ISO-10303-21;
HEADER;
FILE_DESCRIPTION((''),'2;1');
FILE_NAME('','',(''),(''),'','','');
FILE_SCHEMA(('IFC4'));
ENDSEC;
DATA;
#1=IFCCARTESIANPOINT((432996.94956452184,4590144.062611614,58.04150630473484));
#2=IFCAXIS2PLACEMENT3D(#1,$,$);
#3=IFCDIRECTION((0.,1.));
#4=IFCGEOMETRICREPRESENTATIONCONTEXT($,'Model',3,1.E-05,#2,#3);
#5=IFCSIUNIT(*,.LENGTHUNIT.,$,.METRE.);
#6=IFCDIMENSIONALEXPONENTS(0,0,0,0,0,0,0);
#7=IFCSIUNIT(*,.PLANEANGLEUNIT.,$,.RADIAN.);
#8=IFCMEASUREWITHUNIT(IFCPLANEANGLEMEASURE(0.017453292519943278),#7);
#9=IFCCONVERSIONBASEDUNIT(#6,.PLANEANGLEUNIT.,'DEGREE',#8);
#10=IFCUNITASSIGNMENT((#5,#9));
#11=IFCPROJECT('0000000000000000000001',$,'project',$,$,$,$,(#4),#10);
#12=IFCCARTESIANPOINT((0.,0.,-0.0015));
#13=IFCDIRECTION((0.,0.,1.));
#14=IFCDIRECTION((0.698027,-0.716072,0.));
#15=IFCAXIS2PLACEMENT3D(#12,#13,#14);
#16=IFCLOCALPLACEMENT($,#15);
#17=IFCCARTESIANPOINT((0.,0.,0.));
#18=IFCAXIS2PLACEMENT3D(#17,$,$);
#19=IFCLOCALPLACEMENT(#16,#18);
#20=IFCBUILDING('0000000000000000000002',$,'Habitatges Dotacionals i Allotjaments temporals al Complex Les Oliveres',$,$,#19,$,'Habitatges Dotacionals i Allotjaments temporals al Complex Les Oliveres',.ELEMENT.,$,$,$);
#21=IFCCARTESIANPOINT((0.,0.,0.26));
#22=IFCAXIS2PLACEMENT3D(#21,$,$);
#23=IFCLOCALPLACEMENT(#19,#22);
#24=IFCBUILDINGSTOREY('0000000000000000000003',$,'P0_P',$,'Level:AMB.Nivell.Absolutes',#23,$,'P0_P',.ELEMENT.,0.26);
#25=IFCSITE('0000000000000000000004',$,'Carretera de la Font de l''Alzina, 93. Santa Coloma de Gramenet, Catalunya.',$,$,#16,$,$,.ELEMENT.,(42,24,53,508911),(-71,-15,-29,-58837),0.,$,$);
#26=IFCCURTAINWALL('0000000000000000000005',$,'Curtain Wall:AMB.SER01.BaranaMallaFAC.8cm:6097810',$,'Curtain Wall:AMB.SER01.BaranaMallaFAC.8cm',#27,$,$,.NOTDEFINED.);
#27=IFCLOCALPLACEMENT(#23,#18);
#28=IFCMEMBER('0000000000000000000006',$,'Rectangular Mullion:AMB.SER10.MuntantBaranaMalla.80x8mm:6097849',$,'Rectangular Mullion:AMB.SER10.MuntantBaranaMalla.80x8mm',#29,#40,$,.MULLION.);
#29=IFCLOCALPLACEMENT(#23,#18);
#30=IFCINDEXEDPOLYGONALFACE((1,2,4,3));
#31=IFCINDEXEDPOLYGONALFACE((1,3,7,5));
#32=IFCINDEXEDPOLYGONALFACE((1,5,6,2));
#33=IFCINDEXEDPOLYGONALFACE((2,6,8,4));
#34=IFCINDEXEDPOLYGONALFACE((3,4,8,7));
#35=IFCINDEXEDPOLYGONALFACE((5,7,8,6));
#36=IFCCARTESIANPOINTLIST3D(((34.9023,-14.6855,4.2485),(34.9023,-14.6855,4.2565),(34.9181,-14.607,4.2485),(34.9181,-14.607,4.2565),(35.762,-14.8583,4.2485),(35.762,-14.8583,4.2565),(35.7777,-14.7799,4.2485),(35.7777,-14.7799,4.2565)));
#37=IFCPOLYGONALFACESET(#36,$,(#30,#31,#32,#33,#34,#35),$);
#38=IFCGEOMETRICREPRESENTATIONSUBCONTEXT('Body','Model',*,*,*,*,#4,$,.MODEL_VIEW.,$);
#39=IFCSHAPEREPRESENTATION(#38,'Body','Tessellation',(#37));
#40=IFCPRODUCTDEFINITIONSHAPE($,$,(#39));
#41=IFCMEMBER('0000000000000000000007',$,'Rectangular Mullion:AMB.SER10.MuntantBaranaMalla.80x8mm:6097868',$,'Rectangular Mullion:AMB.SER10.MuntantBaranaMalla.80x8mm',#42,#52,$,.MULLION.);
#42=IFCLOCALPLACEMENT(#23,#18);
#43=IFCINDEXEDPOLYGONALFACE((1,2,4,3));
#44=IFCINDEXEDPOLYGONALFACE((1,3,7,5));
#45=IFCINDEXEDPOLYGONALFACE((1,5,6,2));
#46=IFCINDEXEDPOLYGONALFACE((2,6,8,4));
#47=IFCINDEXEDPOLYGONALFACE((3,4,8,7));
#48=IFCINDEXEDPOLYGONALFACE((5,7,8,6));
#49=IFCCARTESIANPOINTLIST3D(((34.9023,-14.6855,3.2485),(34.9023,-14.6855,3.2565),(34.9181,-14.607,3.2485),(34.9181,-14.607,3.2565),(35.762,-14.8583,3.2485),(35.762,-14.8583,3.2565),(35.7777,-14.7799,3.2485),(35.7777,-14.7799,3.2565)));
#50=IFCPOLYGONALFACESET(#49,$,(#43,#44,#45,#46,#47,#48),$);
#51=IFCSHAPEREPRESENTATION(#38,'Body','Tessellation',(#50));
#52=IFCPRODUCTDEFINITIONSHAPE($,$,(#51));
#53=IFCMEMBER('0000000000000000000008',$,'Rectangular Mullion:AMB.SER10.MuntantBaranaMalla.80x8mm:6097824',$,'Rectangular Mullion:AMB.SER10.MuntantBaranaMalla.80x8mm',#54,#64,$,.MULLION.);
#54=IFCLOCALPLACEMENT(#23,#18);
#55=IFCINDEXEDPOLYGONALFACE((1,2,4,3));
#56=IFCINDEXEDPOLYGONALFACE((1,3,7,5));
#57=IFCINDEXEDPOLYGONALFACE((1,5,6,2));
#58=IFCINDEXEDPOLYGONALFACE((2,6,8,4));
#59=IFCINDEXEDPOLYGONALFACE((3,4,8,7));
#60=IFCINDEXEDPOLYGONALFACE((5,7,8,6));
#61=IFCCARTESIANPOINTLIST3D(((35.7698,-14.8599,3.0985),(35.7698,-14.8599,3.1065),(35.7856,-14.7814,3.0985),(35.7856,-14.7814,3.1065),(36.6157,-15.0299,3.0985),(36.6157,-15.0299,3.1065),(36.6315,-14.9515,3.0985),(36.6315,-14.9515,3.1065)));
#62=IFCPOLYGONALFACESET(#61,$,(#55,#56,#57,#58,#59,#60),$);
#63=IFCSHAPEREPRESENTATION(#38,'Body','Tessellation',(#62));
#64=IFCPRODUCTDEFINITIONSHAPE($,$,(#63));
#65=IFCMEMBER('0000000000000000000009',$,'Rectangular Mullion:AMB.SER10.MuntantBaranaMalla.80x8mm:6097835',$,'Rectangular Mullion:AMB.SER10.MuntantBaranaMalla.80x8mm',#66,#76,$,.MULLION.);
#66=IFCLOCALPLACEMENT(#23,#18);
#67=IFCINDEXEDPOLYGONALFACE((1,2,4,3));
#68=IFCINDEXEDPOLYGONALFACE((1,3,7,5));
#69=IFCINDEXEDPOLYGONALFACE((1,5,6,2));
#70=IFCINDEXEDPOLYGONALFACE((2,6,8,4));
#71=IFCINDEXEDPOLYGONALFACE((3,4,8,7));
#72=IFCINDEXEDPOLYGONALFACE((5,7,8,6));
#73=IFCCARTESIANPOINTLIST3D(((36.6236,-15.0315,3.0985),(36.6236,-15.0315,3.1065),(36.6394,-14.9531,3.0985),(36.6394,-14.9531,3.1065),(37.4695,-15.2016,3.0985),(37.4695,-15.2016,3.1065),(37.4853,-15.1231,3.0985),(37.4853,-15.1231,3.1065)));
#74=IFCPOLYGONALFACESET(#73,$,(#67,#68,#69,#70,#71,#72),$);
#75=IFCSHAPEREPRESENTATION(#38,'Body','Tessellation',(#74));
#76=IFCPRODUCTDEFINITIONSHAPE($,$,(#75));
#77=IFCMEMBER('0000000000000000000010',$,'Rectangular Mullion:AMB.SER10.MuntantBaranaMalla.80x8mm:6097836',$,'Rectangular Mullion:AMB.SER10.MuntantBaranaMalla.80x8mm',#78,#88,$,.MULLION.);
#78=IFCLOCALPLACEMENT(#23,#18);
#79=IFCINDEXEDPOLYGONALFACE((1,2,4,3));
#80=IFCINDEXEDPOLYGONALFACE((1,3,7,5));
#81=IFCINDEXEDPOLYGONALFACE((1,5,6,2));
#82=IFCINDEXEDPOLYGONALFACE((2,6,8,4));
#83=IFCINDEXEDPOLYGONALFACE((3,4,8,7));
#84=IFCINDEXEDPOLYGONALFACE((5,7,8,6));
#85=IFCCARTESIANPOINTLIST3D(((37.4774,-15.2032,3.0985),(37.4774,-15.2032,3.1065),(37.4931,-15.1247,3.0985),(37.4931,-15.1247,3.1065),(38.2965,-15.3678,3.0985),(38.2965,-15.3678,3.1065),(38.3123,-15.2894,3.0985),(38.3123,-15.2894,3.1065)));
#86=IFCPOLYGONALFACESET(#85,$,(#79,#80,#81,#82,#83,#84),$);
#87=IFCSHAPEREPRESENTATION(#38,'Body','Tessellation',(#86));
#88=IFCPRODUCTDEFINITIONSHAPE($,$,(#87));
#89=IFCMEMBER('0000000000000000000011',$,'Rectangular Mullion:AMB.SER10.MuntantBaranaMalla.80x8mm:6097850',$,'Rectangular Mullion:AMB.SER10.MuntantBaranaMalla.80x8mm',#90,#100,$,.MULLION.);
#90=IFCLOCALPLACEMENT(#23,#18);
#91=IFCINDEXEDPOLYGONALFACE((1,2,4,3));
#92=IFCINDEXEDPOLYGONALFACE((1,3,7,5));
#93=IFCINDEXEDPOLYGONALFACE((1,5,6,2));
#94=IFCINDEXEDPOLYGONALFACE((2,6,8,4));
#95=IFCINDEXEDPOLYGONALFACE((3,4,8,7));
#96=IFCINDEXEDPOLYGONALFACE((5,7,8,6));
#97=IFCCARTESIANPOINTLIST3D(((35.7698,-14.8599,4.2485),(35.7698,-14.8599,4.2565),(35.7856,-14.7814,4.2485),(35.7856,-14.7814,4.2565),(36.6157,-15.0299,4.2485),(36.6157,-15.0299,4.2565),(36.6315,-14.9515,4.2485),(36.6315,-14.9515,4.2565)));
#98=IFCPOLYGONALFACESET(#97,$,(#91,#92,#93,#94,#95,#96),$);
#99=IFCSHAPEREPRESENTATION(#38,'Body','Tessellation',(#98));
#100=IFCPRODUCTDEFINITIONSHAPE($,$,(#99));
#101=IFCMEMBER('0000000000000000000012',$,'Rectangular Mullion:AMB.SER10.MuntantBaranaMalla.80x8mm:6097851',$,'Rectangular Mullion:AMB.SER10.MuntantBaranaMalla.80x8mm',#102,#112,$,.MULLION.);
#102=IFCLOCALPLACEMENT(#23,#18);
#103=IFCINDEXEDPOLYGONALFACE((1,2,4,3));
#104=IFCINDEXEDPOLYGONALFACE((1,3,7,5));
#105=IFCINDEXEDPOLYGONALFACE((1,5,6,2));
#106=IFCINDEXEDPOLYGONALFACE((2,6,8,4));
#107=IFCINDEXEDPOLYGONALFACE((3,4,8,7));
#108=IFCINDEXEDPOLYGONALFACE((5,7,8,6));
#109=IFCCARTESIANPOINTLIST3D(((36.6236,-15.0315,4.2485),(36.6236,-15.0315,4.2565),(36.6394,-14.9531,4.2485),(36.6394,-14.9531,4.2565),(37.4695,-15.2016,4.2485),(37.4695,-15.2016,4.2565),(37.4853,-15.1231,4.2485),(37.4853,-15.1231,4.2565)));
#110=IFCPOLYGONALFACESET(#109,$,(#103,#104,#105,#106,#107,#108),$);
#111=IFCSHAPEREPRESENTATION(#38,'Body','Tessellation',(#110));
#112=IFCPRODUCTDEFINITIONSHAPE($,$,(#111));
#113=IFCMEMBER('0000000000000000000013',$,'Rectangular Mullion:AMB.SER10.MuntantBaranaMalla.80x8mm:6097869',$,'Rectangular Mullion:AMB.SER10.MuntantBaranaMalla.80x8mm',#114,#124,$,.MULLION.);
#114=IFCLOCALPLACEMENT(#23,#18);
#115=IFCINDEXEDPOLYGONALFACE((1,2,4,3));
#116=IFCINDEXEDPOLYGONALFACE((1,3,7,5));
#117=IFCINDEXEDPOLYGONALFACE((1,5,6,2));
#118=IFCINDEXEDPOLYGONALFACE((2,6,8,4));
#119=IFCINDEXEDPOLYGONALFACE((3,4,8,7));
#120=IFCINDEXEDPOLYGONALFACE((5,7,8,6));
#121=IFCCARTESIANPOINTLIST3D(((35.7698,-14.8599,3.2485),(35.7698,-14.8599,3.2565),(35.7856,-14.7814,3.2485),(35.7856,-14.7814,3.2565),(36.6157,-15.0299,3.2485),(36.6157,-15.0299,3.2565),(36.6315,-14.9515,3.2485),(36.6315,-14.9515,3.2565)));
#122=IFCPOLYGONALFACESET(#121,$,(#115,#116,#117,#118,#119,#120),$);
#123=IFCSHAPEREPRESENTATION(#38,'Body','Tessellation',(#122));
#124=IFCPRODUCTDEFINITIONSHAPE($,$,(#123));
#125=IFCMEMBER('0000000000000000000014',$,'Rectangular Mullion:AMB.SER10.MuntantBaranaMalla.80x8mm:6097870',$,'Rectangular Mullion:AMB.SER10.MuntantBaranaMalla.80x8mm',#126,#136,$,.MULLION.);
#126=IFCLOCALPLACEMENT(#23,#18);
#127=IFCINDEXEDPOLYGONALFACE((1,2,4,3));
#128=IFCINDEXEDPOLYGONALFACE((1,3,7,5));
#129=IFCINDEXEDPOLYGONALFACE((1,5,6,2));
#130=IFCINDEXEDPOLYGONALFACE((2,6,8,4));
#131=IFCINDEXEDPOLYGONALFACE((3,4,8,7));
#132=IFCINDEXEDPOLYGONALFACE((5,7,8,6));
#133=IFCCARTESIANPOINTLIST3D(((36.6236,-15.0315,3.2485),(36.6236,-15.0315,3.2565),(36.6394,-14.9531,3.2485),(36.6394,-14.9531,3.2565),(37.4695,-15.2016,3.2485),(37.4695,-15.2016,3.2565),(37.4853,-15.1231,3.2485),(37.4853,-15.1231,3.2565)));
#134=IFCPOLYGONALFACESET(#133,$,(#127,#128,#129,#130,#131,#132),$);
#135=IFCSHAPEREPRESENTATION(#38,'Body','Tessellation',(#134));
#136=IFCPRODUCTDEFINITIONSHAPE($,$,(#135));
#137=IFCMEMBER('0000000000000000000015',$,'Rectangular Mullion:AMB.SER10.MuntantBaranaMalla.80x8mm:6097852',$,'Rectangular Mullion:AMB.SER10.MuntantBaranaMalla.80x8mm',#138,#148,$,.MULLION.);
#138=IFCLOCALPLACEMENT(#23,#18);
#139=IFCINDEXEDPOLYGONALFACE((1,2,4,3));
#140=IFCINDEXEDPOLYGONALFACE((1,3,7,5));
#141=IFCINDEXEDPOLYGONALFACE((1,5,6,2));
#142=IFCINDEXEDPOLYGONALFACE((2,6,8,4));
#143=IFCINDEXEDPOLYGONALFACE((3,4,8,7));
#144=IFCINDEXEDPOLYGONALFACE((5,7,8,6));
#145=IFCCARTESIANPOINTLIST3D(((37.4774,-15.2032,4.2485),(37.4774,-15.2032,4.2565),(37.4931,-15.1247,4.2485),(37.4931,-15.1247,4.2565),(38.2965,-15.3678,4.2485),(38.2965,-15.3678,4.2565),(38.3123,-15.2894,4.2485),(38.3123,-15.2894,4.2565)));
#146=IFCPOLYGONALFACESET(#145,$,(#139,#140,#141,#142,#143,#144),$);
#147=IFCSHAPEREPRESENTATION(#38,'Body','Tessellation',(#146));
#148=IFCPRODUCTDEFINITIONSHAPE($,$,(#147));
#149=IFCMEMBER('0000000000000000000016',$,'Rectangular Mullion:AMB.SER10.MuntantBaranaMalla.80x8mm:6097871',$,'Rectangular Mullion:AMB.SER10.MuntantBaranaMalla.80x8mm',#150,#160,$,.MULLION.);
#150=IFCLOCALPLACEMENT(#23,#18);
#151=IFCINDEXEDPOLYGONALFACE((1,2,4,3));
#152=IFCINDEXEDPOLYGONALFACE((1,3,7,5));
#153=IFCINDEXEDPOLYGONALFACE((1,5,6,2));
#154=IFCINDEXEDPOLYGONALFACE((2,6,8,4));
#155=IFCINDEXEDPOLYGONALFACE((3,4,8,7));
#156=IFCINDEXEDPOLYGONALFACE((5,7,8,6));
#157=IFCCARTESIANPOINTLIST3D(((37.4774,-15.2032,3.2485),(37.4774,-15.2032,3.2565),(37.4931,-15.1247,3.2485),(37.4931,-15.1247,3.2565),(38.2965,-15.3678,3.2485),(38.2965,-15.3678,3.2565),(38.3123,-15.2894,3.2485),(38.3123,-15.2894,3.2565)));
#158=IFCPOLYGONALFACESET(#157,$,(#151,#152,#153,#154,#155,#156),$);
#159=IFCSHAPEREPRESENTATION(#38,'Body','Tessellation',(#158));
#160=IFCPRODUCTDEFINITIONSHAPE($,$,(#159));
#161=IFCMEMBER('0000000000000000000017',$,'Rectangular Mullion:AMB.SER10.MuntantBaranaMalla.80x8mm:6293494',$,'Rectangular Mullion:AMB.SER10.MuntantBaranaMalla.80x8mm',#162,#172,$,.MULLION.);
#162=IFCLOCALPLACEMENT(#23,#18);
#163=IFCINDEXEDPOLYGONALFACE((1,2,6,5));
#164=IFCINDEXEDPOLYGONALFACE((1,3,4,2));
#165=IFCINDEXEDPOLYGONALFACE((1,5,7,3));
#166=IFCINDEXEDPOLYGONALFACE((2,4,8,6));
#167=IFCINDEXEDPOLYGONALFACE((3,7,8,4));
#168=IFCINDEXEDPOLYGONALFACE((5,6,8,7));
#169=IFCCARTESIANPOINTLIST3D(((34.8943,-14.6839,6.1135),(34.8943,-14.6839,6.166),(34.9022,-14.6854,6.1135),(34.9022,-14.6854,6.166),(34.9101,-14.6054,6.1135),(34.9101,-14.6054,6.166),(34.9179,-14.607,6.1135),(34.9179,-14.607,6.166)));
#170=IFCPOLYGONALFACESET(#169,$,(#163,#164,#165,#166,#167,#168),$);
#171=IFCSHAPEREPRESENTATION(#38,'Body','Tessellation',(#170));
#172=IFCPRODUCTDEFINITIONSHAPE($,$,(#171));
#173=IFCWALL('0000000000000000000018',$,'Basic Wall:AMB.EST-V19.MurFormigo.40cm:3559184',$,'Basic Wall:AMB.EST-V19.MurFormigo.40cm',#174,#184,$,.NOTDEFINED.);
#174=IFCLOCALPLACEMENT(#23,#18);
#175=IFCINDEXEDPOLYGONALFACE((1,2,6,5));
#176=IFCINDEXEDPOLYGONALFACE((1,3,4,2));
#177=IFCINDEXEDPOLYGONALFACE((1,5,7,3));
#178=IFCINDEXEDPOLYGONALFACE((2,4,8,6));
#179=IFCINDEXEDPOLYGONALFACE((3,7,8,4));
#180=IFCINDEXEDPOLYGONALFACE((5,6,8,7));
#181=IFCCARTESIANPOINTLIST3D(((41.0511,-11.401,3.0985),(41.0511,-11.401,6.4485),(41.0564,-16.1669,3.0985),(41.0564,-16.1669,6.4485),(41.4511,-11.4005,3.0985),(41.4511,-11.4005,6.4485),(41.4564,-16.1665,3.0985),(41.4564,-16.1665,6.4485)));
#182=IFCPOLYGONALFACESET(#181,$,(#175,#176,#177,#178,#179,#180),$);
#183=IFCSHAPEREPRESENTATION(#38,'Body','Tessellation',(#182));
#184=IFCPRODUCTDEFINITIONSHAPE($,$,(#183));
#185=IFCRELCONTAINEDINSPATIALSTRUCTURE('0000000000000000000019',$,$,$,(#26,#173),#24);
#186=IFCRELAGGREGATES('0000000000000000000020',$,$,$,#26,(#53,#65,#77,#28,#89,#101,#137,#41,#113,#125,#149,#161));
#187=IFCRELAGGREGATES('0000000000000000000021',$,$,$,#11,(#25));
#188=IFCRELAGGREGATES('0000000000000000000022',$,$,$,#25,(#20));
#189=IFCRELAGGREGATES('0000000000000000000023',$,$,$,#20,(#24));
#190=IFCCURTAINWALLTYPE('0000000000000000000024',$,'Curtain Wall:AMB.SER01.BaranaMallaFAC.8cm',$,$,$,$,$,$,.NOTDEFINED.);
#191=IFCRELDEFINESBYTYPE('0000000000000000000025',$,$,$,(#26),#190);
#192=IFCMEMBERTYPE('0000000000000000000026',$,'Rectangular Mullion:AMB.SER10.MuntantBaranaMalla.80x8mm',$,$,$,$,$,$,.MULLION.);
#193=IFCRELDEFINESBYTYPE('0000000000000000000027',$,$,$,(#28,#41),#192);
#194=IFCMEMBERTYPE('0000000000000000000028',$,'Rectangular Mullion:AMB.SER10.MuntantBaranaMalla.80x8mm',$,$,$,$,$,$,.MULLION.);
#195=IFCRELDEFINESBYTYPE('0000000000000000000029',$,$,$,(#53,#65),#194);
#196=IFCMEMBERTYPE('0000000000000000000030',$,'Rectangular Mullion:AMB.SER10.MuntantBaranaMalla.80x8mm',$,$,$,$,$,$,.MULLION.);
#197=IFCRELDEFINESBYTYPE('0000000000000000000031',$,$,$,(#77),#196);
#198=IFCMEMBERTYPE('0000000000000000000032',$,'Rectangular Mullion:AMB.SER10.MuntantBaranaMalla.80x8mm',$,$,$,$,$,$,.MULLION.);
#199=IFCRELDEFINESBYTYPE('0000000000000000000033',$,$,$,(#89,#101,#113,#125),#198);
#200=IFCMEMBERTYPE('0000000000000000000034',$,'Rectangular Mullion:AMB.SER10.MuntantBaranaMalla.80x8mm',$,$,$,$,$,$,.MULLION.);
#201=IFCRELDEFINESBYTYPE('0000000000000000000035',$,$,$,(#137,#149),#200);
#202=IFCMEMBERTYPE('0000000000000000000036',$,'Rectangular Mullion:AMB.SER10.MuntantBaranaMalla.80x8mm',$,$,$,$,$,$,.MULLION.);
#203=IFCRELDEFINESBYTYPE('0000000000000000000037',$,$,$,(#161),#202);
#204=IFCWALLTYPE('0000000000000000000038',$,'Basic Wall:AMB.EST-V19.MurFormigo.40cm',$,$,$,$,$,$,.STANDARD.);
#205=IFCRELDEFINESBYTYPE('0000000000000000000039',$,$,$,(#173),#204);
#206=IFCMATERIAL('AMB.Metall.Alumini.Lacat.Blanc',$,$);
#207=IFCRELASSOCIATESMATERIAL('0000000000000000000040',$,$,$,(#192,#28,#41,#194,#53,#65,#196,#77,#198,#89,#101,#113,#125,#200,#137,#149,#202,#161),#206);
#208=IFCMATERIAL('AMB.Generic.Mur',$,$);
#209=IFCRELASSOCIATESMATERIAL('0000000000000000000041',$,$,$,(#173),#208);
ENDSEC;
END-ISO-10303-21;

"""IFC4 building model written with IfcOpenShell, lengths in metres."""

from ifc_helpers import new_model, entity, si_unit, converted_unit, direction, frame, origin, place, context, subcontext, project, spatial, indexed_curve, outline, extrude, source, transform, mapped, material, type_object, type_shapes, element, aggregate, save


model = new_model("IFC4")

# Units and contexts
model_context = context("Model", 3, precision=1e-05, world=frame((432996.94956452184, 4590144.062611614, 58.04150630473484)), true_north=direction((0.0, 1.0)))
body_context = subcontext(model_context, "Body", "Model", "MODEL_VIEW")
ifc_project = project(units=[si_unit("LENGTHUNIT", "METRE"), converted_unit("PLANEANGLEUNIT", "DEGREE", entity("IfcPlaneAngleMeasure", 0.017453292519943278), si_unit("PLANEANGLEUNIT", "RADIAN"), dimensions=[0, 0, 0, 0, 0, 0, 0])], contexts=[model_context])

# Site, building, storey
site_placement = place(None, frame((0.0, 0.0, -0.0015), z_axis=(0.0, 0.0, 1.0), x_axis=(0.698027, -0.716072, 0.0)))
site = spatial("IfcSite", under=ifc_project, at=site_placement, Name="Carretera de la Font de l'Alzina, 93. Santa Coloma de Gramenet, Catalunya.", CompositionType="ELEMENT", RefLatitude=(42, 24, 53, 508911), RefLongitude=(-71, -15, -29, -58837), RefElevation=0.0)
building_placement = place(site_placement, origin())
building = spatial("IfcBuilding", under=site, at=building_placement, Name="Habitatges Dotacionals i Allotjaments temporals al Complex Les Oliveres", LongName="Habitatges Dotacionals i Allotjaments temporals al Complex Les Oliveres", CompositionType="ELEMENT")
storey_placement = place(building_placement, frame((0.0, 0.0, 0.26)))
storey = spatial("IfcBuildingStorey", under=building, at=storey_placement, Name="P0_P", ObjectType="Level:AMB.Nivell.Absolutes", LongName="P0_P", CompositionType="ELEMENT", Elevation=0.26)

# Curtain wall, members
curtain_wall_type = type_object("IfcCurtainWallType", Name="Curtain Wall:AMB.SER01.BaranaMallaFAC.8cm", PredefinedType="NOTDEFINED")
curtain_wall_placement = place(storey_placement, frame((0.0, 0.0, -0.26)))
curtain_wall = element("IfcCurtainWall", 1, at=curtain_wall_placement, inside=storey, type_object=curtain_wall_type, Name="Curtain Wall:AMB.SER01.BaranaMallaFAC.8cm:6097810", ObjectType="Curtain Wall:AMB.SER01.BaranaMallaFAC.8cm", PredefinedType="NOTDEFINED")
ifc_material_1 = material(Name="AMB.Metall.Alumini.Lacat.Blanc")
member_type_1 = type_object("IfcMemberType", Name="Rectangular Mullion:AMB.SER10.MuntantBaranaMalla.80x8mm", PredefinedType="MULLION", material=ifc_material_1)
shared_shape_1 = source(origin(), body_context, "Body", "SweptSolid", [
    extrude(outline(indexed_curve([(-0.004, -0.04), (0.004, -0.04), (0.004, 0.04), (-0.004, 0.04), (-0.004, -0.04)], self_intersect=False)), frame((0.0, -0.04, -0.8769), z_axis=(0.0, 0.0, 1.0), x_axis=(-1.0, 0.0, 0.0)), (0.0, 0.0, 1.0), 0.8769),
])
type_shapes(member_type_1, [shared_shape_1])
member_1_placement = place(curtain_wall_placement, frame((35.762, -14.8583, 4.5125), z_axis=(0.980384, -0.197097, 0.0), x_axis=(0.0, 0.0, 1.0)))
member_1 = element("IfcMember", 2, at=member_1_placement, type_object=member_type_1, material=ifc_material_1, Name="Rectangular Mullion:AMB.SER10.MuntantBaranaMalla.80x8mm:6097849", ObjectType="Rectangular Mullion:AMB.SER10.MuntantBaranaMalla.80x8mm", PredefinedType="MULLION", context=body_context, shape_type="MappedRepresentation", body=[
    mapped(shared_shape_1, transform((0.0, 0.0, 0.0), scale=1.0)),
])
member_2_placement = place(curtain_wall_placement, frame((35.762, -14.8583, 3.5125), z_axis=(0.980384, -0.197097, 0.0), x_axis=(0.0, 0.0, 1.0)))
member_2 = element("IfcMember", 3, at=member_2_placement, type_object=member_type_1, material=ifc_material_1, Name="Rectangular Mullion:AMB.SER10.MuntantBaranaMalla.80x8mm:6097868", ObjectType="Rectangular Mullion:AMB.SER10.MuntantBaranaMalla.80x8mm", PredefinedType="MULLION", context=body_context, shape_type="MappedRepresentation", body=[
    mapped(shared_shape_1, transform((0.0, 0.0, 0.0), scale=1.0)),
])
member_type_2 = type_object("IfcMemberType", Name="Rectangular Mullion:AMB.SER10.MuntantBaranaMalla.80x8mm", PredefinedType="MULLION", material=ifc_material_1)
shared_shape_2 = source(origin(), body_context, "Body", "SweptSolid", [
    extrude(outline(indexed_curve([(-0.004, -0.04), (0.004, -0.04), (0.004, 0.04), (-0.004, 0.04), (-0.004, -0.04)], self_intersect=False)), frame((-0.004, -0.04, -0.8629), z_axis=(0.0, 0.0, 1.0), x_axis=(-1.0, 0.0, 0.0)), (0.0, 0.0, 1.0), 0.8629),
])
type_shapes(member_type_2, [shared_shape_2])
member_3_placement = place(curtain_wall_placement, frame((35.7698, -14.8599, 3.3585), z_axis=(-0.980384, 0.197097, 0.0), x_axis=(0.0, 0.0, -1.0)))
member_3 = element("IfcMember", 4, at=member_3_placement, type_object=member_type_2, material=ifc_material_1, Name="Rectangular Mullion:AMB.SER10.MuntantBaranaMalla.80x8mm:6097824", ObjectType="Rectangular Mullion:AMB.SER10.MuntantBaranaMalla.80x8mm", PredefinedType="MULLION", context=body_context, shape_type="MappedRepresentation", body=[
    mapped(shared_shape_2, transform((0.0, 0.0, 0.0), scale=1.0)),
])
member_4_placement = place(curtain_wall_placement, frame((36.6236, -15.0315, 3.3585), z_axis=(-0.980384, 0.197097, 0.0), x_axis=(0.0, 0.0, -1.0)))
member_4 = element("IfcMember", 5, at=member_4_placement, type_object=member_type_2, material=ifc_material_1, Name="Rectangular Mullion:AMB.SER10.MuntantBaranaMalla.80x8mm:6097835", ObjectType="Rectangular Mullion:AMB.SER10.MuntantBaranaMalla.80x8mm", PredefinedType="MULLION", context=body_context, shape_type="MappedRepresentation", body=[
    mapped(shared_shape_2, transform((0.0, 0.0, 0.0), scale=1.0)),
])
member_type_3 = type_object("IfcMemberType", Name="Rectangular Mullion:AMB.SER10.MuntantBaranaMalla.80x8mm", PredefinedType="MULLION", material=ifc_material_1)
shared_shape_3 = source(origin(), body_context, "Body", "SweptSolid", [
    extrude(outline(indexed_curve([(-0.004, -0.04), (0.004, -0.04), (0.004, 0.04), (-0.004, 0.04), (-0.004, -0.04)], self_intersect=False)), frame((-0.004, -0.04, -0.8356), z_axis=(0.0, 0.0, 1.0), x_axis=(-1.0, 0.0, 0.0)), (0.0, 0.0, 1.0), 0.8356),
])
type_shapes(member_type_3, [shared_shape_3])
member_5_placement = place(curtain_wall_placement, frame((37.4774, -15.2032, 3.3585), z_axis=(-0.980384, 0.197097, 0.0), x_axis=(0.0, 0.0, -1.0)))
member_5 = element("IfcMember", 6, at=member_5_placement, type_object=member_type_3, material=ifc_material_1, Name="Rectangular Mullion:AMB.SER10.MuntantBaranaMalla.80x8mm:6097836", ObjectType="Rectangular Mullion:AMB.SER10.MuntantBaranaMalla.80x8mm", PredefinedType="MULLION", context=body_context, shape_type="MappedRepresentation", body=[
    mapped(shared_shape_3, transform((0.0, 0.0, 0.0), scale=1.0)),
])
member_type_4 = type_object("IfcMemberType", Name="Rectangular Mullion:AMB.SER10.MuntantBaranaMalla.80x8mm", PredefinedType="MULLION", material=ifc_material_1)
shared_shape_4 = source(origin(), body_context, "Body", "SweptSolid", [
    extrude(outline(indexed_curve([(-0.004, -0.04), (0.004, -0.04), (0.004, 0.04), (-0.004, 0.04), (-0.004, -0.04)], self_intersect=False)), frame((0.0, -0.04, -0.8629), z_axis=(0.0, 0.0, 1.0), x_axis=(-1.0, 0.0, 0.0)), (0.0, 0.0, 1.0), 0.8629),
])
type_shapes(member_type_4, [shared_shape_4])
member_6_placement = place(curtain_wall_placement, frame((36.6157, -15.0299, 4.5125), z_axis=(0.980384, -0.197097, 0.0), x_axis=(0.0, 0.0, 1.0)))
member_6 = element("IfcMember", 7, at=member_6_placement, type_object=member_type_4, material=ifc_material_1, Name="Rectangular Mullion:AMB.SER10.MuntantBaranaMalla.80x8mm:6097850", ObjectType="Rectangular Mullion:AMB.SER10.MuntantBaranaMalla.80x8mm", PredefinedType="MULLION", context=body_context, shape_type="MappedRepresentation", body=[
    mapped(shared_shape_4, transform((0.0, 0.0, 0.0), scale=1.0)),
])
member_7_placement = place(curtain_wall_placement, frame((37.4695, -15.2016, 4.5125), z_axis=(0.980384, -0.197097, 0.0), x_axis=(0.0, 0.0, 1.0)))
member_7 = element("IfcMember", 8, at=member_7_placement, type_object=member_type_4, material=ifc_material_1, Name="Rectangular Mullion:AMB.SER10.MuntantBaranaMalla.80x8mm:6097851", ObjectType="Rectangular Mullion:AMB.SER10.MuntantBaranaMalla.80x8mm", PredefinedType="MULLION", context=body_context, shape_type="MappedRepresentation", body=[
    mapped(shared_shape_4, transform((0.0, 0.0, 0.0), scale=1.0)),
])
member_8_placement = place(curtain_wall_placement, frame((36.6157, -15.0299, 3.5125), z_axis=(0.980384, -0.197097, 0.0), x_axis=(0.0, 0.0, 1.0)))
member_8 = element("IfcMember", 9, at=member_8_placement, type_object=member_type_4, material=ifc_material_1, Name="Rectangular Mullion:AMB.SER10.MuntantBaranaMalla.80x8mm:6097869", ObjectType="Rectangular Mullion:AMB.SER10.MuntantBaranaMalla.80x8mm", PredefinedType="MULLION", context=body_context, shape_type="MappedRepresentation", body=[
    mapped(shared_shape_4, transform((0.0, 0.0, 0.0), scale=1.0)),
])
member_9_placement = place(curtain_wall_placement, frame((37.4695, -15.2016, 3.5125), z_axis=(0.980384, -0.197097, 0.0), x_axis=(0.0, 0.0, 1.0)))
member_9 = element("IfcMember", 10, at=member_9_placement, type_object=member_type_4, material=ifc_material_1, Name="Rectangular Mullion:AMB.SER10.MuntantBaranaMalla.80x8mm:6097870", ObjectType="Rectangular Mullion:AMB.SER10.MuntantBaranaMalla.80x8mm", PredefinedType="MULLION", context=body_context, shape_type="MappedRepresentation", body=[
    mapped(shared_shape_4, transform((0.0, 0.0, 0.0), scale=1.0)),
])
member_type_5 = type_object("IfcMemberType", Name="Rectangular Mullion:AMB.SER10.MuntantBaranaMalla.80x8mm", PredefinedType="MULLION", material=ifc_material_1)
shared_shape_5 = source(origin(), body_context, "Body", "SweptSolid", [
    extrude(outline(indexed_curve([(-0.004, -0.04), (0.004, -0.04), (0.004, 0.04), (-0.004, 0.04), (-0.004, -0.04)], self_intersect=False)), frame((0.0, -0.04, -0.8356), z_axis=(0.0, 0.0, 1.0), x_axis=(-1.0, 0.0, 0.0)), (0.0, 0.0, 1.0), 0.8356),
])
type_shapes(member_type_5, [shared_shape_5])
member_10_placement = place(curtain_wall_placement, frame((38.2965, -15.3678, 4.5125), z_axis=(0.980384, -0.197097, 0.0), x_axis=(0.0, 0.0, 1.0)))
member_10 = element("IfcMember", 11, at=member_10_placement, type_object=member_type_5, material=ifc_material_1, Name="Rectangular Mullion:AMB.SER10.MuntantBaranaMalla.80x8mm:6097852", ObjectType="Rectangular Mullion:AMB.SER10.MuntantBaranaMalla.80x8mm", PredefinedType="MULLION", context=body_context, shape_type="MappedRepresentation", body=[
    mapped(shared_shape_5, transform((0.0, 0.0, 0.0), scale=1.0)),
])
member_11_placement = place(curtain_wall_placement, frame((38.2965, -15.3678, 3.5125), z_axis=(0.980384, -0.197097, 0.0), x_axis=(0.0, 0.0, 1.0)))
member_11 = element("IfcMember", 12, at=member_11_placement, type_object=member_type_5, material=ifc_material_1, Name="Rectangular Mullion:AMB.SER10.MuntantBaranaMalla.80x8mm:6097871", ObjectType="Rectangular Mullion:AMB.SER10.MuntantBaranaMalla.80x8mm", PredefinedType="MULLION", context=body_context, shape_type="MappedRepresentation", body=[
    mapped(shared_shape_5, transform((0.0, 0.0, 0.0), scale=1.0)),
])
member_type_6 = type_object("IfcMemberType", Name="Rectangular Mullion:AMB.SER10.MuntantBaranaMalla.80x8mm", PredefinedType="MULLION", material=ifc_material_1)
shared_shape_6 = source(origin(), body_context, "Body", "SweptSolid", [
    extrude(outline(indexed_curve([(-0.004, -0.04), (0.004, -0.04), (0.004, 0.04), (-0.004, 0.04), (-0.004, -0.04)], self_intersect=False)), frame((0.0, -0.04, -0.0525), z_axis=(0.0, 0.0, 1.0), x_axis=(-1.0, 0.0, 0.0)), (0.0, 0.0, 1.0), 0.0525),
])
type_shapes(member_type_6, [shared_shape_6])
member_12_placement = place(curtain_wall_placement, frame((34.8982, -14.6846, 6.3735), z_axis=(0.0, 0.0, -1.0), x_axis=(0.980384, -0.197097, 0.0)))
member_12 = element("IfcMember", 13, at=member_12_placement, type_object=member_type_6, material=ifc_material_1, Name="Rectangular Mullion:AMB.SER10.MuntantBaranaMalla.80x8mm:6293494", ObjectType="Rectangular Mullion:AMB.SER10.MuntantBaranaMalla.80x8mm", PredefinedType="MULLION", context=body_context, shape_type="MappedRepresentation", body=[
    mapped(shared_shape_6, transform((0.0, 0.0, 0.0), scale=1.0)),
])
aggregate(curtain_wall, [member_3, member_4, member_5, member_1, member_6, member_7, member_10, member_2, member_8, member_9, member_11, member_12])

# Wall
ifc_material_2 = material(Name="AMB.Generic.Mur")
wall_type_1 = type_object("IfcWallType", Name="Basic Wall:AMB.EST-V19.MurFormigo.40cm", PredefinedType="STANDARD")
wall_1_placement = place(storey_placement, frame((41.2511, -11.4008, 3.0985), z_axis=(0.0, 0.0, 1.0), x_axis=(0.001099, -0.999999, 0.0)))
element("IfcWall", 14, at=wall_1_placement, inside=storey, type_object=wall_type_1, material=ifc_material_2, Name="Basic Wall:AMB.EST-V19.MurFormigo.40cm:3559184", ObjectType="Basic Wall:AMB.EST-V19.MurFormigo.40cm", PredefinedType="NOTDEFINED", context=body_context, shape_type="SweptSolid", body=[
    extrude(outline(indexed_curve([(4.766, 0.2), (0.0, 0.2), (0.0, -0.2), (4.766, -0.2), (4.766, 0.2)], self_intersect=False)), origin(), (0.0, 0.0, 1.0), 3.35),
])

save(model, "model.ifc")
